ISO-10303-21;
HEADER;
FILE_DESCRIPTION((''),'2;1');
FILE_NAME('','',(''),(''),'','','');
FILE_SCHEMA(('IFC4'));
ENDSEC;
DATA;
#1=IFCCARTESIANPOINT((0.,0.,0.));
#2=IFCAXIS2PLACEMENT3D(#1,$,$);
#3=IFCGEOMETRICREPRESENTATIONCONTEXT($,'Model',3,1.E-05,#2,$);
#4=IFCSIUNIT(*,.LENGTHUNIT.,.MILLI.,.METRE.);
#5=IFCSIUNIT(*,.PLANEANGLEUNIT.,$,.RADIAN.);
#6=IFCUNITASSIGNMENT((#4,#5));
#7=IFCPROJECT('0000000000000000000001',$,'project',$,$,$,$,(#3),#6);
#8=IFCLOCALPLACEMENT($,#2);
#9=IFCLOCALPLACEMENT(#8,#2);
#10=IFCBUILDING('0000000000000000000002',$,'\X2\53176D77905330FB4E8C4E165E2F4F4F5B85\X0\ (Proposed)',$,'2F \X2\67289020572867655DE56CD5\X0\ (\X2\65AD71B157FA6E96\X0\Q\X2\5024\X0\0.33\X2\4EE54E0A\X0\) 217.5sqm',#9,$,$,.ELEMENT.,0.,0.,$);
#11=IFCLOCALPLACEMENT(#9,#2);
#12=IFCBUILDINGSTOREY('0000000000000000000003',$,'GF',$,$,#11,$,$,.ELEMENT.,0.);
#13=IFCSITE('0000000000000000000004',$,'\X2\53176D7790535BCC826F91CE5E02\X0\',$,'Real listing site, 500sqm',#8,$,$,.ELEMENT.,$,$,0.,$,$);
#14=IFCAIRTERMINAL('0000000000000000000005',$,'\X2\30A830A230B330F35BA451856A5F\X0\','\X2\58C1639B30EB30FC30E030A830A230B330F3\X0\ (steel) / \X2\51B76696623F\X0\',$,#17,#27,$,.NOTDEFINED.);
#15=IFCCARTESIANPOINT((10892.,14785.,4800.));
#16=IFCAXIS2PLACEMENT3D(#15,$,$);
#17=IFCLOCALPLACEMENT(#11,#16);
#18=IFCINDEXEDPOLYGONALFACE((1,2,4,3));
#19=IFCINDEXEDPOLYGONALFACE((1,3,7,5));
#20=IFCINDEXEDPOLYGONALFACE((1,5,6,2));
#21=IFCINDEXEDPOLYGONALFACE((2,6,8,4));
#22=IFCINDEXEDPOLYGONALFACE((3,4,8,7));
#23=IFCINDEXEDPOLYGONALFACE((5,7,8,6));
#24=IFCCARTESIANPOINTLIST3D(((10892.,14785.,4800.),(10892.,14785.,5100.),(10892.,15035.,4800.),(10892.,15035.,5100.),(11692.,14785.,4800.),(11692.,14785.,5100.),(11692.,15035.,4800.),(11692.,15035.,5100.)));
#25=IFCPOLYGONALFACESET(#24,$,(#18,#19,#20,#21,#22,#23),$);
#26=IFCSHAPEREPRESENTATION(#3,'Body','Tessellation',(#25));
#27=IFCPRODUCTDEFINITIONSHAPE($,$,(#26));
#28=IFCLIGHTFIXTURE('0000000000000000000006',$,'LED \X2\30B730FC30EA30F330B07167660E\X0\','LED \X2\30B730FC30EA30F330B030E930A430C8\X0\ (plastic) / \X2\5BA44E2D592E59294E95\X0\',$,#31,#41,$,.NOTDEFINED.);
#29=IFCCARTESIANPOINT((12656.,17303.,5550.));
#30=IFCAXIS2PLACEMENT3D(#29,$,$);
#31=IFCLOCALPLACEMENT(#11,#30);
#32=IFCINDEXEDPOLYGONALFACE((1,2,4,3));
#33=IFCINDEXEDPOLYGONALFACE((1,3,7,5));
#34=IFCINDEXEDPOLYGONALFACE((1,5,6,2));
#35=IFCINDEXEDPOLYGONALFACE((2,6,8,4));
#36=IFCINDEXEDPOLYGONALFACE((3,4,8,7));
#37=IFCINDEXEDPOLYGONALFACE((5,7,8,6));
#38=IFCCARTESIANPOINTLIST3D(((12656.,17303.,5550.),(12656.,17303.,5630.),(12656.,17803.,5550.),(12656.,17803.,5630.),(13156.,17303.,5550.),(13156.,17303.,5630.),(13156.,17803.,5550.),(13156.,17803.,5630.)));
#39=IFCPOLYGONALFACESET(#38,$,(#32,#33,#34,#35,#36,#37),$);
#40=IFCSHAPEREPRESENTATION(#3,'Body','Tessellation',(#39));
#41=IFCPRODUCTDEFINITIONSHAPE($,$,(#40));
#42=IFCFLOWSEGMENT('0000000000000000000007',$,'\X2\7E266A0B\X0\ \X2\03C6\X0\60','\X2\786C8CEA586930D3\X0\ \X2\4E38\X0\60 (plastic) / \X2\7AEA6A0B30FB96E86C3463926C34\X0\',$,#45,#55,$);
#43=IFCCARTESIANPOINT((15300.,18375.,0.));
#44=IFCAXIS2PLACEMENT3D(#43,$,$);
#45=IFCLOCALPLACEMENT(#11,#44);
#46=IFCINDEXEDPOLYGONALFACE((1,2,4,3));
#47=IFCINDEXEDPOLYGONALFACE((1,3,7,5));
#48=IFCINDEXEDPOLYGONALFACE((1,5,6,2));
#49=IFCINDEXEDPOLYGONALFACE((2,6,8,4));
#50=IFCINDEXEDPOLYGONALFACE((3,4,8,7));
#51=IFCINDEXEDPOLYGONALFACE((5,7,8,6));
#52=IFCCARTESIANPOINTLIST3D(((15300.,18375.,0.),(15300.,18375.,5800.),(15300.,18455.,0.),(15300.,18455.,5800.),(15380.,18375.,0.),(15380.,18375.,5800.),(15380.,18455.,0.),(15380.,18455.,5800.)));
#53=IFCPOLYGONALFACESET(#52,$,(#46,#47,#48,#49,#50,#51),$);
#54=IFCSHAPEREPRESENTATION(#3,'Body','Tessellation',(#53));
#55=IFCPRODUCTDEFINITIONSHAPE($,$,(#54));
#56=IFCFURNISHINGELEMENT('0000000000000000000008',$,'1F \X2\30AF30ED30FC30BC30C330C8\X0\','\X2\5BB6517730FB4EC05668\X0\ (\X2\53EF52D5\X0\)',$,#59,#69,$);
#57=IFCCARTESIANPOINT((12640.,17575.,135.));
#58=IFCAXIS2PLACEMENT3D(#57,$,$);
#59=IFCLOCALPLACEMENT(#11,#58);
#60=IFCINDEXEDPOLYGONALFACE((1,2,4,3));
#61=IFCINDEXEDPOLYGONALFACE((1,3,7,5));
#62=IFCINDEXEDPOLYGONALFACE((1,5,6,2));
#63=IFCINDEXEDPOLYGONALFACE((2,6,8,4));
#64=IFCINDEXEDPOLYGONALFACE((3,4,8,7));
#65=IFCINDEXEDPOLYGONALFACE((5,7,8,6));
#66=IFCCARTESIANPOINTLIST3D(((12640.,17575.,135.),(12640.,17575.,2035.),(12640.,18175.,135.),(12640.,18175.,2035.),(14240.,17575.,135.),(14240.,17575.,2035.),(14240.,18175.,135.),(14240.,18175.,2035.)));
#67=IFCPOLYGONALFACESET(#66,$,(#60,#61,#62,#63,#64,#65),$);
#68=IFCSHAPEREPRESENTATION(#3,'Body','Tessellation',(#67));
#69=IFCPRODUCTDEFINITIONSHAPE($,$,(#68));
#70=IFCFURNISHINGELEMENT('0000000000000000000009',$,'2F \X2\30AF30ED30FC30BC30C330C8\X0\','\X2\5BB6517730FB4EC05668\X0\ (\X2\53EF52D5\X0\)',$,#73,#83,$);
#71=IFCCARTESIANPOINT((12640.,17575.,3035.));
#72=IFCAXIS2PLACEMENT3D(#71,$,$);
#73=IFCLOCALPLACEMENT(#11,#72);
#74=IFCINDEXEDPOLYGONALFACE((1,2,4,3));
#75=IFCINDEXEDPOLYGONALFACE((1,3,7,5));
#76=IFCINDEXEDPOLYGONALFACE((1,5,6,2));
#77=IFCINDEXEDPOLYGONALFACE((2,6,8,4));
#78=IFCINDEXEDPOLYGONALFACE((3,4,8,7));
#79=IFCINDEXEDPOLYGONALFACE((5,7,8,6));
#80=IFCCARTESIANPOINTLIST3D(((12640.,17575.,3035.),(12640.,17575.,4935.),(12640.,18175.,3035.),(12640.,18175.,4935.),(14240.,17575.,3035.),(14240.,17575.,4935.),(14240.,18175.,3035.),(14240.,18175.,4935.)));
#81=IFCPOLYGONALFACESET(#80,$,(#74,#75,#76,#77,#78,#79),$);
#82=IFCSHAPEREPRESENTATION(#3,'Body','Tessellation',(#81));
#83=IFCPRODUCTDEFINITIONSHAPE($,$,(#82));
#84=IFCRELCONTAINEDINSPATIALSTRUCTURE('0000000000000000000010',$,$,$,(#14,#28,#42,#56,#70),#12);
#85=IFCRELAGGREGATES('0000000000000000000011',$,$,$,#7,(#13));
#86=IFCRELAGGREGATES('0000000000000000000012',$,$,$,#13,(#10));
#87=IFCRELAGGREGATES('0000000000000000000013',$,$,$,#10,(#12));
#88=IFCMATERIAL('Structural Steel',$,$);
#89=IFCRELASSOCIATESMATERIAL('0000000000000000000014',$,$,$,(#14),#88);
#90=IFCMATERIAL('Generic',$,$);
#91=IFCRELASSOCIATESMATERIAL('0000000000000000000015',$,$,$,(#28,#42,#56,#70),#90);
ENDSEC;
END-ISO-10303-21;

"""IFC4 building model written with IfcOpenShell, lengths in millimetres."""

from ifc_helpers import new_model, si_unit, frame, frame_2d, origin, place, context, project, spatial, rectangle, extrude, material, element, save


model = new_model("IFC4")

# Units and contexts
model_context = context("Model", 3, precision=1e-05, world=origin())
ifc_project = project(units=[si_unit("LENGTHUNIT", "METRE", prefix="MILLI"), si_unit("PLANEANGLEUNIT", "RADIAN")], contexts=[model_context])

# Site, building, storey
site_placement = place(None, origin())
site = spatial("IfcSite", under=ifc_project, at=site_placement, Name="北海道富良野市", ObjectType="Real listing site, 500sqm", CompositionType="ELEMENT", RefElevation=0.0)
building_placement = place(site_placement, origin())
building = spatial("IfcBuilding", under=site, at=building_placement, Name="北海道・二世帯住宅 (Proposed)", ObjectType="2F 木造在来工法 (断熱基準Q値0.33以上) 217.5sqm", CompositionType="ELEMENT", ElevationOfRefHeight=0.0, ElevationOfTerrain=0.0)
storey_placement = place(building_placement, origin())
storey = spatial("IfcBuildingStorey", under=building, at=storey_placement, Name="GF", CompositionType="ELEMENT", Elevation=0.0)

# Shared definitions
ifc_material_1 = material(Name="Generic")

# Shared definitions
ifc_material_2 = material(Name="Structural Steel")

# Air terminal
air_terminal_1_placement = place(storey_placement, frame((10892.0, 14785.0, 4800.0)))
element("IfcAirTerminal", 1, at=air_terminal_1_placement, inside=storey, material=ifc_material_2, Name="エアコン室内機", Description="壁掛ルームエアコン (steel) / 冷暖房", PredefinedType="NOTDEFINED", context=model_context, shape_type="SweptSolid", body=[
    extrude(rectangle(XDim=800.0, YDim=250.0, at=frame_2d((400.0, 125.0))), frame((10892.0, 14785.0, 4800.0)), (0.0, 0.0, 1.0), 300.0),
])

# Light fixture
light_fixture_1_placement = place(storey_placement, frame((12656.0, 17303.0, 5550.0)))
element("IfcLightFixture", 2, at=light_fixture_1_placement, inside=storey, material=ifc_material_1, Name="LED シーリング照明", Description="LED シーリングライト (plastic) / 室中央天井", PredefinedType="NOTDEFINED", context=model_context, shape_type="SweptSolid", body=[
    extrude(rectangle(XDim=500.0, YDim=500.0, at=frame_2d((250.0, 250.0))), frame((12656.0, 17303.0, 5550.0)), (0.0, 0.0, 1.0), 80.0),
])

# Flow segment
flow_segment_placement = place(storey_placement, frame((15300.0, 18375.0, 0.0)))
element("IfcFlowSegment", 3, at=flow_segment_placement, inside=storey, material=ifc_material_1, Name="縦樋 φ60", Description="硬質塩ビ 丸60 (plastic) / 竪樋・雨水排水", context=model_context, shape_type="SweptSolid", body=[
    extrude(rectangle(XDim=80.0, YDim=80.0, at=frame_2d((40.0, 40.0))), frame((15300.0, 18375.0, 0.0)), (0.0, 0.0, 1.0), 5800.0),
])

# Furnishing elements
furnishing_1_placement = place(storey_placement, frame((12640.0, 17575.0, 135.0)))
element("IfcFurnishingElement", 4, at=furnishing_1_placement, inside=storey, material=ifc_material_1, Name="1F クローゼット", Description="家具・什器 (可動)", context=model_context, shape_type="SweptSolid", body=[
    extrude(rectangle(XDim=1600.0, YDim=600.0, at=frame_2d((800.0, 300.0))), frame((12640.0, 17575.0, 135.0)), (0.0, 0.0, 1.0), 1900.0),
])
furnishing_2_placement = place(storey_placement, frame((12640.0, 17575.0, 3035.0)))
element("IfcFurnishingElement", 5, at=furnishing_2_placement, inside=storey, material=ifc_material_1, Name="2F クローゼット", Description="家具・什器 (可動)", context=model_context, shape_type="SweptSolid", body=[
    extrude(rectangle(XDim=1600.0, YDim=600.0, at=frame_2d((800.0, 300.0))), frame((12640.0, 17575.0, 3035.0)), (0.0, 0.0, 1.0), 1900.0),
])

save(model, "model.ifc")
